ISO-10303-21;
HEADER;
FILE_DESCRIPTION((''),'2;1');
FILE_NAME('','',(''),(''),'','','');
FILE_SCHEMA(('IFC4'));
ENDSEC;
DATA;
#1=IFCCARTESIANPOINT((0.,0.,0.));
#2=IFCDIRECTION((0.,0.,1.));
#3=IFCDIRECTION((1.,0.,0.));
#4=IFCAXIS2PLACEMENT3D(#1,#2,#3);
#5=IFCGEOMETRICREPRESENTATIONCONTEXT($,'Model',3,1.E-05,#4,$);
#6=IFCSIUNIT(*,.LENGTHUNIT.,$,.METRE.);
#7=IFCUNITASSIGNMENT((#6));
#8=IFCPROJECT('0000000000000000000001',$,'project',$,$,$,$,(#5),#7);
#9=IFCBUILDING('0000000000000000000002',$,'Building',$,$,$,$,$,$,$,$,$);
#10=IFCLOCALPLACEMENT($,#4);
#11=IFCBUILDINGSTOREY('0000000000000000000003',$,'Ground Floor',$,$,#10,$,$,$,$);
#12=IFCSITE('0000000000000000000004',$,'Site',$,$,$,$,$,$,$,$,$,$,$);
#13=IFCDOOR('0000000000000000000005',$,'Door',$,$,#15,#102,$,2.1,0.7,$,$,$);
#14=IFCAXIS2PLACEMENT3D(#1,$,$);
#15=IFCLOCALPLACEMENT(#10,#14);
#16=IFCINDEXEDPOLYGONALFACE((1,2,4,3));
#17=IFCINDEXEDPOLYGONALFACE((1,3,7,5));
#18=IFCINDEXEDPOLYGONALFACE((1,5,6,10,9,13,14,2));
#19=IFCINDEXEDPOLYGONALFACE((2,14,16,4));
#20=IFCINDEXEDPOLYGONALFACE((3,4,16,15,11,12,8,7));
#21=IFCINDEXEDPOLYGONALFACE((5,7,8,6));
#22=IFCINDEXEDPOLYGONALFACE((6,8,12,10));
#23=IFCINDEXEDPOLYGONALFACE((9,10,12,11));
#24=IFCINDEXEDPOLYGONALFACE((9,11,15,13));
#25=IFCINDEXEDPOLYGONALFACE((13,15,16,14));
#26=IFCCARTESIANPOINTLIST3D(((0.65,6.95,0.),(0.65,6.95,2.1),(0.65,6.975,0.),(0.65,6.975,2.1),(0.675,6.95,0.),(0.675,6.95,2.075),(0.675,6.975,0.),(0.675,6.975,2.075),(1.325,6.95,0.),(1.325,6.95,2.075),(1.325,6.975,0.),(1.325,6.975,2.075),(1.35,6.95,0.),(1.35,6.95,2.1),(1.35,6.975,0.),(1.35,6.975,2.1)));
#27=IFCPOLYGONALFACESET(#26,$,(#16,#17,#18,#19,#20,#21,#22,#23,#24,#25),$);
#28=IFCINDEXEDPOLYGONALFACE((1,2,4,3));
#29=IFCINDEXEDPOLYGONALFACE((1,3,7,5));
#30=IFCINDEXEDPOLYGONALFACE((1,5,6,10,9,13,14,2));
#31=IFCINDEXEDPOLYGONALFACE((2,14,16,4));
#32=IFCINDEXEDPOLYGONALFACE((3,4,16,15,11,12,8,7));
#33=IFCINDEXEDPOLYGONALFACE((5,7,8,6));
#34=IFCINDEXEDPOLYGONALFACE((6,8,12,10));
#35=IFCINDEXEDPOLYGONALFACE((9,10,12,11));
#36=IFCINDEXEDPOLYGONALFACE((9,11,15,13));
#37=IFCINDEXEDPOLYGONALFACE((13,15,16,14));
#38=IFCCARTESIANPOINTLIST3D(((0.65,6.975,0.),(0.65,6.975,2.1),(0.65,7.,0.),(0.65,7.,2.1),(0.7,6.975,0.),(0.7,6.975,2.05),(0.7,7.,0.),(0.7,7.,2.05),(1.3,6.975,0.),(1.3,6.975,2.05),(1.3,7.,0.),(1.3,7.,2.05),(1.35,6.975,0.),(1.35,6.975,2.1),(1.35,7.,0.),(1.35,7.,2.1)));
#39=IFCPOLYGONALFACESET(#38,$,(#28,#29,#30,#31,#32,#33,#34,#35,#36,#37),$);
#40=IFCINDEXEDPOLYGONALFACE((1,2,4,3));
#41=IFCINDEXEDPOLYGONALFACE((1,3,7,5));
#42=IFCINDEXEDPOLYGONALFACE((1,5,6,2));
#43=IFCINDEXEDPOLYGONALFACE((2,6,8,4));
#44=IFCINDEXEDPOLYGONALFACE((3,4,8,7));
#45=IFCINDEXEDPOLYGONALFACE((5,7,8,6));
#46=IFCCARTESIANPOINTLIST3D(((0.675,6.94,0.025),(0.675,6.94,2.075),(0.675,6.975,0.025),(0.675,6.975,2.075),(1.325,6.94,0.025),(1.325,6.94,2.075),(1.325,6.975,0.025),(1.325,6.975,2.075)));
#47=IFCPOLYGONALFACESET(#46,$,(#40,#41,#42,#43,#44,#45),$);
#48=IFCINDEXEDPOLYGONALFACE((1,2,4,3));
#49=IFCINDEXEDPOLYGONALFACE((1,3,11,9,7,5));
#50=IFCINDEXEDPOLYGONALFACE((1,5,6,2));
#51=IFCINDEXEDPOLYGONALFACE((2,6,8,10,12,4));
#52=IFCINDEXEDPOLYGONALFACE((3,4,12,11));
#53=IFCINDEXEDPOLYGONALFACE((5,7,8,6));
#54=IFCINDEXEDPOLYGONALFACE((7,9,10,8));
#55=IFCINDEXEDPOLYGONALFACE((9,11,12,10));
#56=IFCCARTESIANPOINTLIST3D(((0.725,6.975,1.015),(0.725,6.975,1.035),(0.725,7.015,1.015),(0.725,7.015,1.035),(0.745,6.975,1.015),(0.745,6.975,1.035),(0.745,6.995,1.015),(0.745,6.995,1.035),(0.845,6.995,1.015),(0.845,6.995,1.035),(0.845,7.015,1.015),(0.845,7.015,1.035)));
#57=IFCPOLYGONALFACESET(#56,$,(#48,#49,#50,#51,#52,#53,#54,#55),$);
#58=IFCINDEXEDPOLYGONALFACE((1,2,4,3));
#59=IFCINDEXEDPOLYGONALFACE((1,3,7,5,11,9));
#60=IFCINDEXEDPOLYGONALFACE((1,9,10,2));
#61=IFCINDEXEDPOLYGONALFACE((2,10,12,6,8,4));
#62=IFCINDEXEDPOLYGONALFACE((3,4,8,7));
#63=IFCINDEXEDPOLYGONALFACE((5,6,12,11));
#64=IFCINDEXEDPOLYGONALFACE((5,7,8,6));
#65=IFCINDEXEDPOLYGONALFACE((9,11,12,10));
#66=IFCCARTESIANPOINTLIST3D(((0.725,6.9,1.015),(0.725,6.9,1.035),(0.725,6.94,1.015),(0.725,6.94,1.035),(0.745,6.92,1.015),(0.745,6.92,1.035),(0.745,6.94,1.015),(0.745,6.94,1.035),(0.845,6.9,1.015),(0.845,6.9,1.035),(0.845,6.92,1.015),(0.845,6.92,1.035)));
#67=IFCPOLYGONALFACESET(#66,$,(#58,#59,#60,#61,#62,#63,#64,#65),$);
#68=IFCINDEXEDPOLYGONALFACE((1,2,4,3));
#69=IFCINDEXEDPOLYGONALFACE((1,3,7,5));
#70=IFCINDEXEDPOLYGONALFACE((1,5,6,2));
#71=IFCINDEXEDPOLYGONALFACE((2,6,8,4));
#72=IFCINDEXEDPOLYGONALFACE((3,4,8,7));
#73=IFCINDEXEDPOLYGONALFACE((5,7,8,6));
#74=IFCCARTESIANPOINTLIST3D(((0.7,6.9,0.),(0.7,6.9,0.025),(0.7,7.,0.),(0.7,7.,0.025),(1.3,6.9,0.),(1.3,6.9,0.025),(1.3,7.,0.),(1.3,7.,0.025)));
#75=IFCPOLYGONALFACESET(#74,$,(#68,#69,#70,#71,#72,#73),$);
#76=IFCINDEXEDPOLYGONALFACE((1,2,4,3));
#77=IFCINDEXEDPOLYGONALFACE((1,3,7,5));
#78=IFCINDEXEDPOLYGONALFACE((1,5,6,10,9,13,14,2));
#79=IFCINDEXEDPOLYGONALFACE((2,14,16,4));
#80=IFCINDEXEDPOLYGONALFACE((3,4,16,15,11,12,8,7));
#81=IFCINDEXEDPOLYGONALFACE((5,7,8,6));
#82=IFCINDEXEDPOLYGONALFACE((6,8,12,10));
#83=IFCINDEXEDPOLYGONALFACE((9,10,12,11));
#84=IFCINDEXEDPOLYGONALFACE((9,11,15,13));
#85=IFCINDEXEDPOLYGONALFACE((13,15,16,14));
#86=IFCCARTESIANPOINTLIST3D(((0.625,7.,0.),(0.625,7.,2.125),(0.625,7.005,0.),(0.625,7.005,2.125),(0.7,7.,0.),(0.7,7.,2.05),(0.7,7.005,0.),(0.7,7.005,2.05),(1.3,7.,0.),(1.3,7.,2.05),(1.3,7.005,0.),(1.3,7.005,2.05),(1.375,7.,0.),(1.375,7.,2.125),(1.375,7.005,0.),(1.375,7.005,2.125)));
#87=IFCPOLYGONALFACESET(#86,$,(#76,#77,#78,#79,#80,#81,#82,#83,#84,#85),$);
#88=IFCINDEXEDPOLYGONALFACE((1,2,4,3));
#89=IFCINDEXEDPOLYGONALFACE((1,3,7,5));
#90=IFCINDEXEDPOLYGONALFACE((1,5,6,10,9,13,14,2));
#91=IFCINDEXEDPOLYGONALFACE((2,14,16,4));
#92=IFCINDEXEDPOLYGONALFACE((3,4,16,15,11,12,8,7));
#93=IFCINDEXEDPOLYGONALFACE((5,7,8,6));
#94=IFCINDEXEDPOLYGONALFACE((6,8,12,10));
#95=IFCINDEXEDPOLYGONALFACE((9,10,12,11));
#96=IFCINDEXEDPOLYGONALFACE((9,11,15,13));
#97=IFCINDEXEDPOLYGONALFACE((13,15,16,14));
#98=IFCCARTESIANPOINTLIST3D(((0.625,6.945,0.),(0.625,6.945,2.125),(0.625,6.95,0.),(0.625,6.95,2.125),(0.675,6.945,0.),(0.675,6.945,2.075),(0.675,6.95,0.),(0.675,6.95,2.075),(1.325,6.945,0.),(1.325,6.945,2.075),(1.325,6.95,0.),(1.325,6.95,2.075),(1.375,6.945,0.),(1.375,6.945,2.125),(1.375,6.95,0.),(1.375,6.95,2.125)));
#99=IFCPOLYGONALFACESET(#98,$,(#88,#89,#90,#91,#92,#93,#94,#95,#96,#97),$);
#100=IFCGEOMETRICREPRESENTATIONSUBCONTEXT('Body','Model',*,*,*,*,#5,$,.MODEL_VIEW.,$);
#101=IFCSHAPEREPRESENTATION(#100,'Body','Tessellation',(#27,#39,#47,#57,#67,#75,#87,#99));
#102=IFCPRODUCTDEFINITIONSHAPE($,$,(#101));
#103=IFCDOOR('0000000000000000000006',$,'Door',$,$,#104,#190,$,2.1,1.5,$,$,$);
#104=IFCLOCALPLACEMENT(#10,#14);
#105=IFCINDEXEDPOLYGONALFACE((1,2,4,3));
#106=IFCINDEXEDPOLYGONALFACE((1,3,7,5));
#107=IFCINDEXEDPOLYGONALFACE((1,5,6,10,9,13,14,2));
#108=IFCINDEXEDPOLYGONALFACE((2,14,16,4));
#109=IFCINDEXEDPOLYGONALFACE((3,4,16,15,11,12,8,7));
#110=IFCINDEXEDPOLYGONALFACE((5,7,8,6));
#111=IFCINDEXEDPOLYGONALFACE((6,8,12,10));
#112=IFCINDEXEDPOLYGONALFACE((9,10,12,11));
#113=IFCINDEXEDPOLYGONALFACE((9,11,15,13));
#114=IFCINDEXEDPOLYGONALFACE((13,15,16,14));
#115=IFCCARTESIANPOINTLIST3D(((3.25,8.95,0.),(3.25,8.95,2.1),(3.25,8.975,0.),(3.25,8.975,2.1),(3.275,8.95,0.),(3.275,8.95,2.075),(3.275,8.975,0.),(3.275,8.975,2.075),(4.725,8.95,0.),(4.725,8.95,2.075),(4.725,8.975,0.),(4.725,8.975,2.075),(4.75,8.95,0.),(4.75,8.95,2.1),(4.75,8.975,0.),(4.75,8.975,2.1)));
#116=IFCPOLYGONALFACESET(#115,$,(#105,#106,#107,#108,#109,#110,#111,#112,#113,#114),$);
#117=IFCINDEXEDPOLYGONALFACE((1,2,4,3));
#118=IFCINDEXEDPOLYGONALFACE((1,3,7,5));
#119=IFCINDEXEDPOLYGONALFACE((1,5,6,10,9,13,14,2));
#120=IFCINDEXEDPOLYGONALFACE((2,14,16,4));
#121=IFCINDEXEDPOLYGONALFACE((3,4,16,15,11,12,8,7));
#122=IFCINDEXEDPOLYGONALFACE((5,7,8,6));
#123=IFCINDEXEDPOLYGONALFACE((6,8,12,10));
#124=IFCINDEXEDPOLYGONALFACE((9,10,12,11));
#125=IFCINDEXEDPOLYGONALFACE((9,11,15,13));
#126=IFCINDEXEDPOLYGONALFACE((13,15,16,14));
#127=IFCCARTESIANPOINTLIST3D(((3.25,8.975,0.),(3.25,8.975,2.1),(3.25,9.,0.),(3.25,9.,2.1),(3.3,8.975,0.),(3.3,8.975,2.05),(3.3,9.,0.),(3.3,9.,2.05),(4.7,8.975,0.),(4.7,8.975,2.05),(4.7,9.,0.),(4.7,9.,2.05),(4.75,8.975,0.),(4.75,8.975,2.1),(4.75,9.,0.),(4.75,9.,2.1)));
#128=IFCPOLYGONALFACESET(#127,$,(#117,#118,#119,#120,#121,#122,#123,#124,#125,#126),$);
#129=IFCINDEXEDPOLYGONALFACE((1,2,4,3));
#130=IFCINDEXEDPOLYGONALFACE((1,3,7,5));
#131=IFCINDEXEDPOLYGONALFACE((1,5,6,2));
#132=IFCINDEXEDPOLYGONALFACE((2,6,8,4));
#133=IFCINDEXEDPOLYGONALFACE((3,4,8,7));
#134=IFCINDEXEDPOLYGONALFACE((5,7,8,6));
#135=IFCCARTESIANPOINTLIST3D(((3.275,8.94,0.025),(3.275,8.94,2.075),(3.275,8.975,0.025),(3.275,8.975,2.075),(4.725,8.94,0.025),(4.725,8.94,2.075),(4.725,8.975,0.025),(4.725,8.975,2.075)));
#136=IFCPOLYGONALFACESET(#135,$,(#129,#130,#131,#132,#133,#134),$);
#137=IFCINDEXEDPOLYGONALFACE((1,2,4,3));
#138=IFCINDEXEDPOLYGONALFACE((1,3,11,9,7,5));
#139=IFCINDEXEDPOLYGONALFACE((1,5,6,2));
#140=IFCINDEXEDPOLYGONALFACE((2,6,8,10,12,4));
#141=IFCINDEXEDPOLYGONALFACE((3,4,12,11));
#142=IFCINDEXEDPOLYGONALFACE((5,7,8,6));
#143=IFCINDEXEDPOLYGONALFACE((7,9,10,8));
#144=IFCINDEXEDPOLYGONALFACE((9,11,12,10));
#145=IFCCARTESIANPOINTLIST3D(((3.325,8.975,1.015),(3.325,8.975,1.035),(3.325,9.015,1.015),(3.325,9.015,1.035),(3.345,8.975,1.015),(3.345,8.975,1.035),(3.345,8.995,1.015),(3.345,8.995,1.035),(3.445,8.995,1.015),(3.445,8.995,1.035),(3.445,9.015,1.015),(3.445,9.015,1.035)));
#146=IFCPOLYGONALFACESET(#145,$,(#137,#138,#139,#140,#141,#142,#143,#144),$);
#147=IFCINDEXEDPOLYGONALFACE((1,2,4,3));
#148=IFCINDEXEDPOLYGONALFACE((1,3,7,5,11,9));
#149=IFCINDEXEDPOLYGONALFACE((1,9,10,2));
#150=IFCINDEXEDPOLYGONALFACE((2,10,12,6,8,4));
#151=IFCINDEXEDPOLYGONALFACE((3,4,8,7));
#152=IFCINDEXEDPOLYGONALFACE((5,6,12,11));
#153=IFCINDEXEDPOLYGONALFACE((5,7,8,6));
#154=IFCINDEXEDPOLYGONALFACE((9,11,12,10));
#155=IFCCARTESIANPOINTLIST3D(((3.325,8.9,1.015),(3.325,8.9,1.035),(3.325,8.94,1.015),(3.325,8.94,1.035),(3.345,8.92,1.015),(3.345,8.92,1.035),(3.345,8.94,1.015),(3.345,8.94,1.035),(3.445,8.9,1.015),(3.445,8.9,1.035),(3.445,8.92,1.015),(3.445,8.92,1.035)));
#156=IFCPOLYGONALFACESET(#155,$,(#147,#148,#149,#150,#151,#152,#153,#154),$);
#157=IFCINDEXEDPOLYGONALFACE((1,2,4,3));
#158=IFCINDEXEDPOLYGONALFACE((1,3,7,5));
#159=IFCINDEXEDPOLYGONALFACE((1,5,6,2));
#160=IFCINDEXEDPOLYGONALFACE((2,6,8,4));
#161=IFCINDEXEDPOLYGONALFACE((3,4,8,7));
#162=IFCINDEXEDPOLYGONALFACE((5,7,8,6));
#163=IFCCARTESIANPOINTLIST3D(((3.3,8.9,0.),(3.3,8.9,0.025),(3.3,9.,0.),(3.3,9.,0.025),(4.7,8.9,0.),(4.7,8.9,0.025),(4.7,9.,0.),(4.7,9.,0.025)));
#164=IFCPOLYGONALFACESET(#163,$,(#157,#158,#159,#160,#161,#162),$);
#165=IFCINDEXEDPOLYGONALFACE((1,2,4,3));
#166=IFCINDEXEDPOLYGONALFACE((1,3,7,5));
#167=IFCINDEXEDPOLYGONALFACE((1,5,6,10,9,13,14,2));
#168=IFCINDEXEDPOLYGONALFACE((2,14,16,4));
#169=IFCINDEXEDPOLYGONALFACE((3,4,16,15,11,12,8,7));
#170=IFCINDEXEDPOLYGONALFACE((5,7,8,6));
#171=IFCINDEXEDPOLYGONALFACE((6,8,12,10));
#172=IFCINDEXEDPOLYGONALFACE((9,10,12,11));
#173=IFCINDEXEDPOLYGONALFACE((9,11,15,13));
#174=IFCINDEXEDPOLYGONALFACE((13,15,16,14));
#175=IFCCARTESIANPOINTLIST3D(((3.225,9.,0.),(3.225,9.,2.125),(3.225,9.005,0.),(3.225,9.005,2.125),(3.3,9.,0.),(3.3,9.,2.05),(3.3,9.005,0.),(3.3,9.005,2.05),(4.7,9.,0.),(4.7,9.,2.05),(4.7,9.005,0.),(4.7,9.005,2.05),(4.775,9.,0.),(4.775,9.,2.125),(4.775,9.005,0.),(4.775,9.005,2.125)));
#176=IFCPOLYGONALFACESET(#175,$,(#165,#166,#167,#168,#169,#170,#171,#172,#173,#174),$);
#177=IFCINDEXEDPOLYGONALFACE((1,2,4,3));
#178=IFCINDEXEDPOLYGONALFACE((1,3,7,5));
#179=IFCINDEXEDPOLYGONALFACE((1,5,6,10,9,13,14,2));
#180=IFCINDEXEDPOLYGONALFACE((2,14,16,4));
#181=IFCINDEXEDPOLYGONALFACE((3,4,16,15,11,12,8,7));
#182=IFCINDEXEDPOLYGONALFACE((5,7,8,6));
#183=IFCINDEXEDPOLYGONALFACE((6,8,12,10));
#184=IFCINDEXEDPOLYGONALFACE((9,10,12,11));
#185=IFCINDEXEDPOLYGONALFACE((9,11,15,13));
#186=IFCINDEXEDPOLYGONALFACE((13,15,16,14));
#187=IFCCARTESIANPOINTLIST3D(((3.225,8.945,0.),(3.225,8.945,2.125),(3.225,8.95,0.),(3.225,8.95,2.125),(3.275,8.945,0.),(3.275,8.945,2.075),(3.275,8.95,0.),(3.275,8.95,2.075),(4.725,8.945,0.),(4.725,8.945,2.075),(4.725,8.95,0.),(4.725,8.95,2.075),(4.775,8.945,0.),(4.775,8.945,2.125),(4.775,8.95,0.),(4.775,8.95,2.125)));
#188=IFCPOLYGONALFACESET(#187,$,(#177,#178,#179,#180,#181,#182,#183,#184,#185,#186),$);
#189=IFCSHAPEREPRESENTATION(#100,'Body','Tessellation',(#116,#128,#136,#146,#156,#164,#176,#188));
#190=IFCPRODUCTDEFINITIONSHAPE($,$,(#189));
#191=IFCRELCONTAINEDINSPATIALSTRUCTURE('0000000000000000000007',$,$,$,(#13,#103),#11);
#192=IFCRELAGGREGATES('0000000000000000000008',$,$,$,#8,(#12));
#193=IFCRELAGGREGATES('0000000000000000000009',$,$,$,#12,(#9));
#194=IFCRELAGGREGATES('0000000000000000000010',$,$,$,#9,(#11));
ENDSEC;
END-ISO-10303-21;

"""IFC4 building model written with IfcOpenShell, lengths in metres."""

from ifc_helpers import new_model, si_unit, frame, origin_with_axes, place, context, subcontext, project, spatial, line, indexed_curve, outline, extrude, element, save


model = new_model("IFC4")

# Units and contexts
model_context = context("Model", 3, precision=1e-05, world=origin_with_axes())
body_context = subcontext(model_context, "Body", "Model", "MODEL_VIEW")
ifc_project = project(units=[si_unit("LENGTHUNIT", "METRE")], contexts=[model_context])

# Site, building, storey
site = spatial("IfcSite", under=ifc_project, Name="Site")
building = spatial("IfcBuilding", under=site, Name="Building")
storey_placement = place(None, origin_with_axes())
storey = spatial("IfcBuildingStorey", under=building, at=storey_placement, Name="Ground Floor")

# Doors
door_1_placement = place(storey_placement, frame((1.35, 7.0, 0.0), z_axis=(0.0, 0.0, 1.0), x_axis=(-1.0, 0.0, 0.0)))
element("IfcDoor", 1, at=door_1_placement, inside=storey, Name="Door", OverallHeight=2.1, OverallWidth=0.7, context=body_context, shape_type="SweptSolid", body=[
    extrude(outline(indexed_curve([(0.0, 0.0), (0.0, 2.1), (0.7, 2.1), (0.7, 0.0), (0.675, 0.0), (0.675, 2.075), (0.025, 2.075), (0.025, 0.0)], segments=[line(1, 2, 3, 4, 5, 6, 7, 8, 1)])), frame((0.0, 0.025, 0.0), z_axis=(0.0, -1.0, 0.0), x_axis=(1.0, 0.0, 0.0)), (0.0, 0.0, -1.0), 0.025),
    extrude(outline(indexed_curve([(0.0, 0.0), (0.0, 2.1), (0.7, 2.1), (0.7, 0.0), (0.65, 0.0), (0.65, 2.05), (0.05, 2.05), (0.05, 0.0)], segments=[line(1, 2, 3, 4, 5, 6, 7, 8, 1)])), frame((0.0, 0.0, 0.0), z_axis=(0.0, -1.0, 0.0), x_axis=(1.0, 0.0, 0.0)), (0.0, 0.0, -1.0), 0.025),
    extrude(outline(indexed_curve([(0.0, 0.0), (0.65, 0.0), (0.65, 0.035), (0.0, 0.035)], segments=[line(1, 2, 3, 4, 1)])), frame((0.025, 0.025, 0.025), z_axis=(0.0, 0.0, 1.0), x_axis=(1.0, 0.0, 0.0)), (0.0, 0.0, 1.0), 2.05),
    extrude(outline(indexed_curve([(0.0, 0.0), (0.0, -0.04), (-0.12, -0.04), (-0.12, -0.02), (-0.02, -0.02), (-0.02, 0.0)], segments=[line(1, 2, 3, 4, 5, 6, 1)])), frame((0.625, 0.025, 1.015), z_axis=(0.0, 0.0, 1.0), x_axis=(1.0, 0.0, 0.0)), (0.0, 0.0, 1.0), 0.02),
    extrude(outline(indexed_curve([(0.0, 0.0), (0.0, 0.04), (-0.12, 0.04), (-0.12, 0.02), (-0.02, 0.02), (-0.02, 0.0)], segments=[line(1, 2, 3, 4, 5, 6, 1)])), frame((0.625, 0.06, 1.015), z_axis=(0.0, 0.0, 1.0), x_axis=(1.0, 0.0, 0.0)), (0.0, 0.0, 1.0), 0.02),
    extrude(outline(indexed_curve([(0.0, 0.0), (0.6, 0.0), (0.6, 0.1), (0.0, 0.1)], segments=[line(1, 2, 3, 4, 1)])), frame((0.05, 0.0, 0.0), z_axis=(0.0, 0.0, 1.0), x_axis=(1.0, 0.0, 0.0)), (0.0, 0.0, 1.0), 0.025),
    extrude(outline(indexed_curve([(0.0, 0.0), (0.0, 2.125), (0.75, 2.125), (0.75, 0.0), (0.675, 0.0), (0.675, 2.05), (0.075, 2.05), (0.075, 0.0)], segments=[line(1, 2, 3, 4, 5, 6, 7, 8, 1)])), frame((-0.025, -0.005, 0.0), z_axis=(0.0, -1.0, 0.0), x_axis=(1.0, 0.0, 0.0)), (0.0, 0.0, -1.0), 0.005),
    extrude(outline(indexed_curve([(0.0, 0.0), (0.0, 2.125), (0.75, 2.125), (0.75, 0.0), (0.7, 0.0), (0.7, 2.075), (0.05, 2.075), (0.05, 0.0)], segments=[line(1, 2, 3, 4, 5, 6, 7, 8, 1)])), frame((-0.025, 0.05, 0.0), z_axis=(0.0, -1.0, 0.0), x_axis=(1.0, 0.0, 0.0)), (0.0, 0.0, -1.0), 0.005),
])
door_2_placement = place(storey_placement, frame((4.75, 9.0, 0.0), z_axis=(0.0, 0.0, 1.0), x_axis=(-1.0, 0.0, 0.0)))
element("IfcDoor", 2, at=door_2_placement, inside=storey, Name="Door", OverallHeight=2.1, OverallWidth=1.5, context=body_context, shape_type="SweptSolid", body=[
    extrude(outline(indexed_curve([(0.0, 0.0), (0.0, 2.1), (1.5, 2.1), (1.5, 0.0), (1.475, 0.0), (1.475, 2.075), (0.025, 2.075), (0.025, 0.0)], segments=[line(1, 2, 3, 4, 5, 6, 7, 8, 1)])), frame((0.0, 0.025, 0.0), z_axis=(0.0, -1.0, 0.0), x_axis=(1.0, 0.0, 0.0)), (0.0, 0.0, -1.0), 0.025),
    extrude(outline(indexed_curve([(0.0, 0.0), (0.0, 2.1), (1.5, 2.1), (1.5, 0.0), (1.45, 0.0), (1.45, 2.05), (0.05, 2.05), (0.05, 0.0)], segments=[line(1, 2, 3, 4, 5, 6, 7, 8, 1)])), frame((0.0, 0.0, 0.0), z_axis=(0.0, -1.0, 0.0), x_axis=(1.0, 0.0, 0.0)), (0.0, 0.0, -1.0), 0.025),
    extrude(outline(indexed_curve([(0.0, 0.0), (1.45, 0.0), (1.45, 0.035), (0.0, 0.035)], segments=[line(1, 2, 3, 4, 1)])), frame((0.025, 0.025, 0.025), z_axis=(0.0, 0.0, 1.0), x_axis=(1.0, 0.0, 0.0)), (0.0, 0.0, 1.0), 2.05),
    extrude(outline(indexed_curve([(0.0, 0.0), (0.0, -0.04), (-0.12, -0.04), (-0.12, -0.02), (-0.02, -0.02), (-0.02, 0.0)], segments=[line(1, 2, 3, 4, 5, 6, 1)])), frame((1.425, 0.025, 1.015), z_axis=(0.0, 0.0, 1.0), x_axis=(1.0, 0.0, 0.0)), (0.0, 0.0, 1.0), 0.02),
    extrude(outline(indexed_curve([(0.0, 0.0), (0.0, 0.04), (-0.12, 0.04), (-0.12, 0.02), (-0.02, 0.02), (-0.02, 0.0)], segments=[line(1, 2, 3, 4, 5, 6, 1)])), frame((1.425, 0.06, 1.015), z_axis=(0.0, 0.0, 1.0), x_axis=(1.0, 0.0, 0.0)), (0.0, 0.0, 1.0), 0.02),
    extrude(outline(indexed_curve([(0.0, 0.0), (1.4, 0.0), (1.4, 0.1), (0.0, 0.1)], segments=[line(1, 2, 3, 4, 1)])), frame((0.05, 0.0, 0.0), z_axis=(0.0, 0.0, 1.0), x_axis=(1.0, 0.0, 0.0)), (0.0, 0.0, 1.0), 0.025),
    extrude(outline(indexed_curve([(0.0, 0.0), (0.0, 2.125), (1.55, 2.125), (1.55, 0.0), (1.475, 0.0), (1.475, 2.05), (0.075, 2.05), (0.075, 0.0)], segments=[line(1, 2, 3, 4, 5, 6, 7, 8, 1)])), frame((-0.025, -0.005, 0.0), z_axis=(0.0, -1.0, 0.0), x_axis=(1.0, 0.0, 0.0)), (0.0, 0.0, -1.0), 0.005),
    extrude(outline(indexed_curve([(0.0, 0.0), (0.0, 2.125), (1.55, 2.125), (1.55, 0.0), (1.5, 0.0), (1.5, 2.075), (0.05, 2.075), (0.05, 0.0)], segments=[line(1, 2, 3, 4, 5, 6, 7, 8, 1)])), frame((-0.025, 0.05, 0.0), z_axis=(0.0, -1.0, 0.0), x_axis=(1.0, 0.0, 0.0)), (0.0, 0.0, -1.0), 0.005),
])

save(model, "model.ifc")
